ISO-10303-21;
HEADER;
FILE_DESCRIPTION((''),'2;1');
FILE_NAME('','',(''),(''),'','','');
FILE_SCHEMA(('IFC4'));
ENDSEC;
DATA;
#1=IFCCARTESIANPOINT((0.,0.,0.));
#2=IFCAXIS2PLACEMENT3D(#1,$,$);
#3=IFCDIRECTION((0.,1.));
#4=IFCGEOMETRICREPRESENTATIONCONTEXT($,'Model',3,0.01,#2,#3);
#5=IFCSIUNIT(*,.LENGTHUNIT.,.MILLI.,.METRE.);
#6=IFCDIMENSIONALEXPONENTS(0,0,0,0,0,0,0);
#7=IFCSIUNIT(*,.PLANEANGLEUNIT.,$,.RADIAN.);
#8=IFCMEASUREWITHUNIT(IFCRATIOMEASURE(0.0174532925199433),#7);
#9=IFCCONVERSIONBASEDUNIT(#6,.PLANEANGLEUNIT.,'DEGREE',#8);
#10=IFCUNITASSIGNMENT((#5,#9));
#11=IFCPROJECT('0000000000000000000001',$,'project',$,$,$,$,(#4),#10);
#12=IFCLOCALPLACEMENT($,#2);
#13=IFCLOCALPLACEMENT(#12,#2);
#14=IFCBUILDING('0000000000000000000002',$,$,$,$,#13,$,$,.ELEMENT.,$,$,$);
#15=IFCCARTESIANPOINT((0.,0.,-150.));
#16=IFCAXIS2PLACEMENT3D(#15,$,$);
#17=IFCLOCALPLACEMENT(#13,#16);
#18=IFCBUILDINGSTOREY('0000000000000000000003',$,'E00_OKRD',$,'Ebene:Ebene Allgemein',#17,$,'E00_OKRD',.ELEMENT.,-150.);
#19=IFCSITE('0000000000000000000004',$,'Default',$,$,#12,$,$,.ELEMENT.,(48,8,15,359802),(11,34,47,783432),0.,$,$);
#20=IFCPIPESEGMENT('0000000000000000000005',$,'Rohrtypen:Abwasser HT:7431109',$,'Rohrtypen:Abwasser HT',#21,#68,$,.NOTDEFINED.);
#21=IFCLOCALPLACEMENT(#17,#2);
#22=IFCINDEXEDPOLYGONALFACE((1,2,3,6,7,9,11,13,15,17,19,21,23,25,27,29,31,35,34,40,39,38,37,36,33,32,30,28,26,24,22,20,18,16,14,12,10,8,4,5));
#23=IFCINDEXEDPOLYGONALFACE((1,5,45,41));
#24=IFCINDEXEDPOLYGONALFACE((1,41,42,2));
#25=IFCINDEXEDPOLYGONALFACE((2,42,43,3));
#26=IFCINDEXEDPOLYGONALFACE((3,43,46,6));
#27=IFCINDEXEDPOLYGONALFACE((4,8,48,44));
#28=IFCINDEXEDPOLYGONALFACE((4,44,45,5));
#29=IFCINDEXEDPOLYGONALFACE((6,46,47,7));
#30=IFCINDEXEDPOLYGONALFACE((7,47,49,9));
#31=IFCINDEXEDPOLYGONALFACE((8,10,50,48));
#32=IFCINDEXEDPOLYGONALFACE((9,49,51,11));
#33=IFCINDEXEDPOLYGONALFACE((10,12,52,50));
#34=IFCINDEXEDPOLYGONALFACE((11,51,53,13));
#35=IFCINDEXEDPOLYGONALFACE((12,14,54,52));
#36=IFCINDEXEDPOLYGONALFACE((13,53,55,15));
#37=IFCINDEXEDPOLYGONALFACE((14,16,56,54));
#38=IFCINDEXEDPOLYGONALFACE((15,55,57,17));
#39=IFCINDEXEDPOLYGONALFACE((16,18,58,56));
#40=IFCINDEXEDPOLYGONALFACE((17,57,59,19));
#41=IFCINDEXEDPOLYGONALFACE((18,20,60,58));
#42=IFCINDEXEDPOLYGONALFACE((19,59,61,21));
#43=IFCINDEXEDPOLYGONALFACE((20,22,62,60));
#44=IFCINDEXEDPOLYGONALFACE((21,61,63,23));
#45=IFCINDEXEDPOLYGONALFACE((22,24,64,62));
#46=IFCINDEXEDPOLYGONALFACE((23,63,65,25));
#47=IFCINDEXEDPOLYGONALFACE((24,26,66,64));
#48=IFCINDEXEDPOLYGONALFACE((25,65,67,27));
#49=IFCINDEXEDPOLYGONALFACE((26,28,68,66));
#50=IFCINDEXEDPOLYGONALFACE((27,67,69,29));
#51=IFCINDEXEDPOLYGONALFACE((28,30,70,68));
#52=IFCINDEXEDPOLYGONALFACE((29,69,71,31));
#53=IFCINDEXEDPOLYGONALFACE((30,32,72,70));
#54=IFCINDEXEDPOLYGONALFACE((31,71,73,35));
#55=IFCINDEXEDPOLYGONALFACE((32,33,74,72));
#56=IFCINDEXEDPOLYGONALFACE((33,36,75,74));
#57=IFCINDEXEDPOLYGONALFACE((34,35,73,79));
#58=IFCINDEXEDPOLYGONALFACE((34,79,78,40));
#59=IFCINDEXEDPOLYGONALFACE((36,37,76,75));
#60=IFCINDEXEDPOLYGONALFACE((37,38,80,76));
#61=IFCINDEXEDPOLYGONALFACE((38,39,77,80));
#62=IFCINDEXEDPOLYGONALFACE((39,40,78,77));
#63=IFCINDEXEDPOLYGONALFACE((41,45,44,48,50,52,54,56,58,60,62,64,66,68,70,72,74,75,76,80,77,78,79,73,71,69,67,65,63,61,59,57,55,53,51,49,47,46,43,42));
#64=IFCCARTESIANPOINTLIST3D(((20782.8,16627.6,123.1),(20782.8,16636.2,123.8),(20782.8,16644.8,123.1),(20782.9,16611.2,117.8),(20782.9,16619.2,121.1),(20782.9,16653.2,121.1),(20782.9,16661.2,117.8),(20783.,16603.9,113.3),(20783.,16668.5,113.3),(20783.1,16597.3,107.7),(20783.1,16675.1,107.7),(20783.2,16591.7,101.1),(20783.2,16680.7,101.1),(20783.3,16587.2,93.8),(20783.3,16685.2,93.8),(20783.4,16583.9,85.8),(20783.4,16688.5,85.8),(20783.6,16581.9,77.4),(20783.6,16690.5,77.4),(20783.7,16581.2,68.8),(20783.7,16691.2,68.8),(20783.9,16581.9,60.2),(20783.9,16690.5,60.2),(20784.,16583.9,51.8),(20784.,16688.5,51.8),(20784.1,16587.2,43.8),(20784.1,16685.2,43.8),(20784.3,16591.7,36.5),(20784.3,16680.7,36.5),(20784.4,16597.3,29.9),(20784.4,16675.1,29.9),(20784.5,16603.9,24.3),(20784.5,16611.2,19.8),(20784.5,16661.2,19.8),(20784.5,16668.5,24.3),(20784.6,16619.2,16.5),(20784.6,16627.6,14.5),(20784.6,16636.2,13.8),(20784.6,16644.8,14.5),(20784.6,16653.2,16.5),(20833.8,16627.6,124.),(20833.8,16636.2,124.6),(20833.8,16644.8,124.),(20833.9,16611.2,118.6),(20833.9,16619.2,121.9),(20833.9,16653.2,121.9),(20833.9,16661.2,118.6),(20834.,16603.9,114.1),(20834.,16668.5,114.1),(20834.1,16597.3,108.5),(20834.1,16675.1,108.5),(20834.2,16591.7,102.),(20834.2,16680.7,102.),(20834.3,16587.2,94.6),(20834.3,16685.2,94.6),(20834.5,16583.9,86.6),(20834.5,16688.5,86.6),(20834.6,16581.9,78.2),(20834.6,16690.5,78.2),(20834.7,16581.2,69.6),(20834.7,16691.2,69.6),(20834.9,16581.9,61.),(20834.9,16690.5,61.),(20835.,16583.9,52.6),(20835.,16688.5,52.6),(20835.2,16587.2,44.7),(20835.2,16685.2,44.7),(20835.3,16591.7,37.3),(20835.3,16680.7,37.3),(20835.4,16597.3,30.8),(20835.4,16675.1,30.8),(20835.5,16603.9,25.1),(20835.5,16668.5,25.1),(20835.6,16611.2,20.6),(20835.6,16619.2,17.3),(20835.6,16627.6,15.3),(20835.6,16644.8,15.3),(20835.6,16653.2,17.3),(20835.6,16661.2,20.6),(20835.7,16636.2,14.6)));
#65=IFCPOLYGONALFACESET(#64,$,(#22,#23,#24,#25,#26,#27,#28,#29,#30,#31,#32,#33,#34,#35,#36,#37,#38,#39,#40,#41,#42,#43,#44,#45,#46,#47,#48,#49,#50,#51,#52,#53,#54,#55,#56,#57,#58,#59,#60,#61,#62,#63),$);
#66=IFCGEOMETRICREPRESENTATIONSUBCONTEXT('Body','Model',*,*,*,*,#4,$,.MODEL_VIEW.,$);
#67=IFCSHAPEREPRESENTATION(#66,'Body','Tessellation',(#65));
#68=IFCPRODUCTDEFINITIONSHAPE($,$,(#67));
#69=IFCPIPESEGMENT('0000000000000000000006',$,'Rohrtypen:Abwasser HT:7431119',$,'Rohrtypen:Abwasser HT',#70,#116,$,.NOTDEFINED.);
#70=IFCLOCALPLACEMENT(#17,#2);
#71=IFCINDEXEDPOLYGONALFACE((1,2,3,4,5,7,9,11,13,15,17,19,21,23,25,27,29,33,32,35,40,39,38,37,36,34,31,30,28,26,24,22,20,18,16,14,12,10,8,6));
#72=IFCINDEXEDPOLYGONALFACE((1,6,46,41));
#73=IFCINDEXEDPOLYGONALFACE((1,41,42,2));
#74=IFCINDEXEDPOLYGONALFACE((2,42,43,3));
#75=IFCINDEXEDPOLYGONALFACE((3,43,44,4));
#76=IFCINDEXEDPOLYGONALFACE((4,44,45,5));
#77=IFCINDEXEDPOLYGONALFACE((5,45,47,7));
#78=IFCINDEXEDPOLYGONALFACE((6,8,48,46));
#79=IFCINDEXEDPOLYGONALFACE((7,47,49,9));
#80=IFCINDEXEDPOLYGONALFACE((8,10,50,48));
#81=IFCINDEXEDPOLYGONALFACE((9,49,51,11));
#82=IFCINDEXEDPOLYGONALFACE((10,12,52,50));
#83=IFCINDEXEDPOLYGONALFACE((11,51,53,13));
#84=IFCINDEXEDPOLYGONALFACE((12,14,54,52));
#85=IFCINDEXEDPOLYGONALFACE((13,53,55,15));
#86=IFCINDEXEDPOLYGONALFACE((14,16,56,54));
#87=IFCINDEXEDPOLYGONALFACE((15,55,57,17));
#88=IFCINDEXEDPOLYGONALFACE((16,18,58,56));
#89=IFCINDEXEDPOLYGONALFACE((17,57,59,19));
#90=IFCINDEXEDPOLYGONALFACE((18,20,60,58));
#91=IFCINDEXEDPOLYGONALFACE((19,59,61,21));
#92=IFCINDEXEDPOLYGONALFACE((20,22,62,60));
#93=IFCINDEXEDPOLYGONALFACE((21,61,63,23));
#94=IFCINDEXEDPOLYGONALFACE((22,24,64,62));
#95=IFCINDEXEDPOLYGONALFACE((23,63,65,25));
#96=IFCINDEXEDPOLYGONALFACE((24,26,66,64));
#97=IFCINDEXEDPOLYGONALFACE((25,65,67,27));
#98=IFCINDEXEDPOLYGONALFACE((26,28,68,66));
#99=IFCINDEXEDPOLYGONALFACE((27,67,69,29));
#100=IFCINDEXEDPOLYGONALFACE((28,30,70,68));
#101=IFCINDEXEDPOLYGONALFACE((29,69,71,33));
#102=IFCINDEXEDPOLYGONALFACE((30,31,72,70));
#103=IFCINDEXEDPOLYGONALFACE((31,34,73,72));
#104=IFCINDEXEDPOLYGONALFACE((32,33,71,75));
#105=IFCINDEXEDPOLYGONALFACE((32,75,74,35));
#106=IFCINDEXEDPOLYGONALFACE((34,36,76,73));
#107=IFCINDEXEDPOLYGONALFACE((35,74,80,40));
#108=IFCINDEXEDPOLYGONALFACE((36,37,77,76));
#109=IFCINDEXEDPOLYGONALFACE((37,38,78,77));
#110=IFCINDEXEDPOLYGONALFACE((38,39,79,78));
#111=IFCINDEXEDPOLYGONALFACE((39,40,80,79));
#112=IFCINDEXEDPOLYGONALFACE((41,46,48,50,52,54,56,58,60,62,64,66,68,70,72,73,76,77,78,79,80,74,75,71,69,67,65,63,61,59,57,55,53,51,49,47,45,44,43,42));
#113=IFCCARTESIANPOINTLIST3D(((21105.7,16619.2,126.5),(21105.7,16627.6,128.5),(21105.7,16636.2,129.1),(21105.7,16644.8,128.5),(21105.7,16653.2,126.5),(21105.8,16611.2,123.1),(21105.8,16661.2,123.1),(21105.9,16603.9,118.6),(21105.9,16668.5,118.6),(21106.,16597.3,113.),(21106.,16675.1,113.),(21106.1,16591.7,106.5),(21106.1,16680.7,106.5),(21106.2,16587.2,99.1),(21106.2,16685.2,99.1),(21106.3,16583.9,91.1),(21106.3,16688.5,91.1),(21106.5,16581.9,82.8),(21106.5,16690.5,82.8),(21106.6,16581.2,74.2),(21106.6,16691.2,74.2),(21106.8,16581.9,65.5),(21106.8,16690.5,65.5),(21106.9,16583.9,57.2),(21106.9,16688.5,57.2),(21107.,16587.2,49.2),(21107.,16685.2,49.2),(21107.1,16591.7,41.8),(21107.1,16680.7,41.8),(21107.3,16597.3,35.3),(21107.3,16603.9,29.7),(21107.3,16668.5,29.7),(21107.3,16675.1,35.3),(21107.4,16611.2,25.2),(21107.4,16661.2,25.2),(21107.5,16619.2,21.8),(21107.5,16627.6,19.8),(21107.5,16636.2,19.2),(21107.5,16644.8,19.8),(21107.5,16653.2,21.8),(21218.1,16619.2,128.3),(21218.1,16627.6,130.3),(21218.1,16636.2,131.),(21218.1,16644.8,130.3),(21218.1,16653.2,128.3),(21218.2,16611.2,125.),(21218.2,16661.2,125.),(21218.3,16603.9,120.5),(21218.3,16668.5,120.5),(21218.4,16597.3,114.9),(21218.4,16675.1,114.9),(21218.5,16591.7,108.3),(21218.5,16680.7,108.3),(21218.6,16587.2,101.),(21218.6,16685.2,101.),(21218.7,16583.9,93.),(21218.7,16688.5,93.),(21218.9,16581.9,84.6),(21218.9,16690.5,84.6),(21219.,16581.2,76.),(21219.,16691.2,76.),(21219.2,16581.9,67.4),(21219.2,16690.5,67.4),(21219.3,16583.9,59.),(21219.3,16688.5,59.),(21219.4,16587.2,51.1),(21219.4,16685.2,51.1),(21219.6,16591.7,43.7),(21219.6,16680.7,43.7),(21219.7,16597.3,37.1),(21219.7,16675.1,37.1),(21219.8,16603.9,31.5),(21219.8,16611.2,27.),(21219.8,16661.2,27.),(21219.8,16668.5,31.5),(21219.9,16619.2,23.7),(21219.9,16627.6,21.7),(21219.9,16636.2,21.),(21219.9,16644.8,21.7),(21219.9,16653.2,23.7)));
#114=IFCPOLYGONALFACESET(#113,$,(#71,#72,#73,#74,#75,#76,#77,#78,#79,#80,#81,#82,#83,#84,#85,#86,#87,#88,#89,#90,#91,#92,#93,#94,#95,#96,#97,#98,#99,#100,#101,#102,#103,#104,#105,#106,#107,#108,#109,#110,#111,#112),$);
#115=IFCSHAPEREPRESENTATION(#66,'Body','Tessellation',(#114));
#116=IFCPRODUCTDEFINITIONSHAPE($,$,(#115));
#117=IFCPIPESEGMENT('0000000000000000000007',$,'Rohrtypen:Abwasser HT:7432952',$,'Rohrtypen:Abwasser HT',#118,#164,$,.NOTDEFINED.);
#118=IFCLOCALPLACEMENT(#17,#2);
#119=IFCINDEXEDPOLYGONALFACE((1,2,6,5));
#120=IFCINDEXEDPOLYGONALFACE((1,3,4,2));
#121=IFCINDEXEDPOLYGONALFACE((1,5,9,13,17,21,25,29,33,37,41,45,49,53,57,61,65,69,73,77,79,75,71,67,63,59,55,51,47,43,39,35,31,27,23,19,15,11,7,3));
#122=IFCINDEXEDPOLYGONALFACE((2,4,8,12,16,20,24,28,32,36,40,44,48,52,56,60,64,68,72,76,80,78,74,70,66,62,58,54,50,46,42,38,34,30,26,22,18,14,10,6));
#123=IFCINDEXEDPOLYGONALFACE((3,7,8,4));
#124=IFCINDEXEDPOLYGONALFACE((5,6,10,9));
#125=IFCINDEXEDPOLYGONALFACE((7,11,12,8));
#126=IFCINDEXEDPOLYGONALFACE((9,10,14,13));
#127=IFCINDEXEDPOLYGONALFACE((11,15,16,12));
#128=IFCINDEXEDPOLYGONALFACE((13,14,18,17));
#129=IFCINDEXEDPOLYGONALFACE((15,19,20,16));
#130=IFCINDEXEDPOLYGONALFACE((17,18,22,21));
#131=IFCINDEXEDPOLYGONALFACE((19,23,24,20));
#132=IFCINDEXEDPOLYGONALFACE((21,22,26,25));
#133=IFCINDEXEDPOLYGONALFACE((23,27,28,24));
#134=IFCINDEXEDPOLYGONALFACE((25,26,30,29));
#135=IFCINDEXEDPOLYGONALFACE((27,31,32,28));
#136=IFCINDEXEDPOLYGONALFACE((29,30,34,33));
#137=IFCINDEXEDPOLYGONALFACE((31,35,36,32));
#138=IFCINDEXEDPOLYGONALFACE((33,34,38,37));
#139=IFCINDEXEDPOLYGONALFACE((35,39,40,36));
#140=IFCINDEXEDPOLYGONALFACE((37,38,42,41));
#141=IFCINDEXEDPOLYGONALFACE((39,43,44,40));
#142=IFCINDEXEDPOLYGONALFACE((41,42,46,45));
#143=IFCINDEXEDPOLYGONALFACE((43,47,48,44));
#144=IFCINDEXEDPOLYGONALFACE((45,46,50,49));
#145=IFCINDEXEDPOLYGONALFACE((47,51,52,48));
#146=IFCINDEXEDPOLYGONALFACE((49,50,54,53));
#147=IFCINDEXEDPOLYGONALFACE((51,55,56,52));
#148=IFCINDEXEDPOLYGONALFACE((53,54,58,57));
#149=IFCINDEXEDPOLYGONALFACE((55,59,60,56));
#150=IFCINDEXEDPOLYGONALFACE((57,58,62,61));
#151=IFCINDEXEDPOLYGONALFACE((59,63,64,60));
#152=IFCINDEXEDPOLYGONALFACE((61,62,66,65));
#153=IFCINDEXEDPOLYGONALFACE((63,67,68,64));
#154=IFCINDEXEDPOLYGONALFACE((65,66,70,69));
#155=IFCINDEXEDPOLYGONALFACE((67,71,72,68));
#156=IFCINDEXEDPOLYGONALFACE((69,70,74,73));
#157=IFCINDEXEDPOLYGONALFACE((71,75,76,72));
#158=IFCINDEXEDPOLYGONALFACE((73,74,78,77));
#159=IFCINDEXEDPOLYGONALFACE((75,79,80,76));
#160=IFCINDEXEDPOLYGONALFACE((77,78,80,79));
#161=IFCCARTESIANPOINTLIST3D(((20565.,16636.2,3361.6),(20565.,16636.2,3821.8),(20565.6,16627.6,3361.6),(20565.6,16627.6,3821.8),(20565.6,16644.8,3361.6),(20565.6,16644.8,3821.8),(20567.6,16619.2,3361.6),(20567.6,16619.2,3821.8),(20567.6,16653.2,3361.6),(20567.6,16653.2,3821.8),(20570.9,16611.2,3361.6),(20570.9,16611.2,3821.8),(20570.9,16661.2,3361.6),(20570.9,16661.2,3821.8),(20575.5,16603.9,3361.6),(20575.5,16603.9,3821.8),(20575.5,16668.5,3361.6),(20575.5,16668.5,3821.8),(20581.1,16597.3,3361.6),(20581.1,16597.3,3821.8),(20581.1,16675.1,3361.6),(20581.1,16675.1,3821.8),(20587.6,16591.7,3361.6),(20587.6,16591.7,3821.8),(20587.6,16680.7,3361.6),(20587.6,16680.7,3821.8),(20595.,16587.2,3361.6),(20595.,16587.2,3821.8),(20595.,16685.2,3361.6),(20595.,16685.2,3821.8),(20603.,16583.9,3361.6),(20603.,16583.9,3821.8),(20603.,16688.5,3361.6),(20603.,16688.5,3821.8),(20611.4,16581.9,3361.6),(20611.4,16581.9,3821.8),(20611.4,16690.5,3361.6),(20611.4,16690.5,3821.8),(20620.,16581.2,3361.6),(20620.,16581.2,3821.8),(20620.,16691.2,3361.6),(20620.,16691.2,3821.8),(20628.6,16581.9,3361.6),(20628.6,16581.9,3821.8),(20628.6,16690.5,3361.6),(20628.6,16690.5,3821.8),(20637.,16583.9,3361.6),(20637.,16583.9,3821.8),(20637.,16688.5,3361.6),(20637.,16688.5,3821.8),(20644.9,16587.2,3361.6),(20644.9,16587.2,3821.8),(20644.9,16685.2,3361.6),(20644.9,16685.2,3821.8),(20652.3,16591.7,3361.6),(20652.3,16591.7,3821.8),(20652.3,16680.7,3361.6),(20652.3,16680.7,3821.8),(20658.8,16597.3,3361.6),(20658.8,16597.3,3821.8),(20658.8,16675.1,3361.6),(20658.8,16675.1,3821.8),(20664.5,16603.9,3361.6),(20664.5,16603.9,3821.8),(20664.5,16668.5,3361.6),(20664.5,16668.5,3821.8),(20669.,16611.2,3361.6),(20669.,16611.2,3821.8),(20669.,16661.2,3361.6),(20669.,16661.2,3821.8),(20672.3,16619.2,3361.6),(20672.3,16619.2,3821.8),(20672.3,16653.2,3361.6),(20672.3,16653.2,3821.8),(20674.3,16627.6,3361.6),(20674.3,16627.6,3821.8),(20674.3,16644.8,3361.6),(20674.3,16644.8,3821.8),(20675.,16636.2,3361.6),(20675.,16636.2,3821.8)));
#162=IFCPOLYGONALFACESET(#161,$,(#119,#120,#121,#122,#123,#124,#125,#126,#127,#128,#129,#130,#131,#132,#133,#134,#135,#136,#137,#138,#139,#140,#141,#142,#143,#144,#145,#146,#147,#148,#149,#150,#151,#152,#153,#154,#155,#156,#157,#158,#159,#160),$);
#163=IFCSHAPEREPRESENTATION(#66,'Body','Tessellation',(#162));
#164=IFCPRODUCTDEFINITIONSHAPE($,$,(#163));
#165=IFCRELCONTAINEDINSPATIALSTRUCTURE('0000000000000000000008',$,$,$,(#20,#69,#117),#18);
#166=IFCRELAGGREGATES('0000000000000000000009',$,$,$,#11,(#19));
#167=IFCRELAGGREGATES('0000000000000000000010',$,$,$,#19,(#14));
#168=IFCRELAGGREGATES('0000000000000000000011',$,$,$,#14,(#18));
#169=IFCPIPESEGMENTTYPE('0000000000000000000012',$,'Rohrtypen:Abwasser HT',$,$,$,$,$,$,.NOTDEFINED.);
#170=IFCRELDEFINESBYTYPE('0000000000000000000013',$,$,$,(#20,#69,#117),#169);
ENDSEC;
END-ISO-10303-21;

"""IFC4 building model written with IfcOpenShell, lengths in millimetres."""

from ifc_helpers import new_model, entity, si_unit, converted_unit, direction, frame, origin, place, context, subcontext, project, spatial, indexed_curve, outline, extrude, type_object, element, save


model = new_model("IFC4")

# Units and contexts
model_context = context("Model", 3, precision=0.01, world=origin(), true_north=direction((0.0, 1.0)))
body_context = subcontext(model_context, "Body", "Model", "MODEL_VIEW")
ifc_project = project(units=[si_unit("LENGTHUNIT", "METRE", prefix="MILLI"), converted_unit("PLANEANGLEUNIT", "DEGREE", entity("IfcRatioMeasure", 0.0174532925199433), si_unit("PLANEANGLEUNIT", "RADIAN"), dimensions=[0, 0, 0, 0, 0, 0, 0])], contexts=[model_context])

# Site, building, storey
site_placement = place(None, origin())
site = spatial("IfcSite", under=ifc_project, at=site_placement, Name="Default", CompositionType="ELEMENT", RefLatitude=(48, 8, 15, 359802), RefLongitude=(11, 34, 47, 783432), RefElevation=0.0)
building_placement = place(site_placement, origin())
building = spatial("IfcBuilding", under=site, at=building_placement, CompositionType="ELEMENT")
storey_placement = place(building_placement, frame((0.0, 0.0, -150.0)))
storey = spatial("IfcBuildingStorey", under=building, at=storey_placement, Name="E00_OKRD", ObjectType="Ebene:Ebene Allgemein", LongName="E00_OKRD", CompositionType="ELEMENT", Elevation=-150.0)

# Pipe segments
pipe_segment_type_1 = type_object("IfcPipeSegmentType", Name="Rohrtypen:Abwasser HT", PredefinedType="NOTDEFINED")
pipe_segment_1_placement = place(storey_placement, origin())
element("IfcPipeSegment", 1, at=pipe_segment_1_placement, inside=storey, type_object=pipe_segment_type_1, Name="Rohrtypen:Abwasser HT:7431109", ObjectType="Rohrtypen:Abwasser HT", PredefinedType="NOTDEFINED", context=body_context, shape_type="SweptSolid", body=[
    extrude(outline(indexed_curve([(55.0, 0.0), (54.3, 8.6), (52.3, 17.0), (49.0, 25.0), (44.5, 32.3), (38.9, 38.9), (32.3, 44.5), (25.0, 49.0), (17.0, 52.3), (8.6, 54.3), (0.0, 55.0), (-8.6, 54.3), (-17.0, 52.3), (-25.0, 49.0), (-32.3, 44.5), (-38.9, 38.9), (-44.5, 32.3), (-49.0, 25.0), (-52.3, 17.0), (-54.3, 8.6), (-55.0, 0.0), (-54.3, -8.6), (-52.3, -17.0), (-49.0, -25.0), (-44.5, -32.3), (-38.9, -38.9), (-32.3, -44.5), (-25.0, -49.0), (-17.0, -52.3), (-8.6, -54.3), (0.0, -55.0), (8.6, -54.3), (17.0, -52.3), (25.0, -49.0), (32.3, -44.5), (38.9, -38.9), (44.5, -32.3), (49.0, -25.0), (52.3, -17.0), (54.3, -8.6), (55.0, 0.0)], self_intersect=False)), frame((20783.7, 16636.2, 68.8), z_axis=(0.999862, 0.0, 0.016604), x_axis=(0.0, 1.0, 0.0)), (0.0, 0.0, 1.0), 51.0),
])
pipe_segment_2_placement = place(storey_placement, origin())
element("IfcPipeSegment", 2, at=pipe_segment_2_placement, inside=storey, type_object=pipe_segment_type_1, Name="Rohrtypen:Abwasser HT:7431119", ObjectType="Rohrtypen:Abwasser HT", PredefinedType="NOTDEFINED", context=body_context, shape_type="SweptSolid", body=[
    extrude(outline(indexed_curve([(55.0, 0.0), (54.3, 8.6), (52.3, 17.0), (49.0, 25.0), (44.5, 32.3), (38.9, 38.9), (32.3, 44.5), (25.0, 49.0), (17.0, 52.3), (8.6, 54.3), (0.0, 55.0), (-8.6, 54.3), (-17.0, 52.3), (-25.0, 49.0), (-32.3, 44.5), (-38.9, 38.9), (-44.5, 32.3), (-49.0, 25.0), (-52.3, 17.0), (-54.3, 8.6), (-55.0, 0.0), (-54.3, -8.6), (-52.3, -17.0), (-49.0, -25.0), (-44.5, -32.3), (-38.9, -38.9), (-32.3, -44.5), (-25.0, -49.0), (-17.0, -52.3), (-8.6, -54.3), (0.0, -55.0), (8.6, -54.3), (17.0, -52.3), (25.0, -49.0), (32.3, -44.5), (38.9, -38.9), (44.5, -32.3), (49.0, -25.0), (52.3, -17.0), (54.3, -8.6), (55.0, 0.0)], self_intersect=False)), frame((21106.6, 16636.2, 74.2), z_axis=(0.999862, 0.0, 0.016604), x_axis=(0.0, 1.0, 0.0)), (0.0, 0.0, 1.0), 112.4),
])
pipe_segment_3_placement = place(storey_placement, origin())
element("IfcPipeSegment", 3, at=pipe_segment_3_placement, inside=storey, type_object=pipe_segment_type_1, Name="Rohrtypen:Abwasser HT:7432952", ObjectType="Rohrtypen:Abwasser HT", PredefinedType="NOTDEFINED", context=body_context, shape_type="SweptSolid", body=[
    extrude(outline(indexed_curve([(55.0, 0.0), (54.3, 8.6), (52.3, 17.0), (49.0, 25.0), (44.5, 32.3), (38.9, 38.9), (32.3, 44.5), (25.0, 49.0), (17.0, 52.3), (8.6, 54.3), (0.0, 55.0), (-8.6, 54.3), (-17.0, 52.3), (-25.0, 49.0), (-32.3, 44.5), (-38.9, 38.9), (-44.5, 32.3), (-49.0, 25.0), (-52.3, 17.0), (-54.3, 8.6), (-55.0, 0.0), (-54.3, -8.6), (-52.3, -17.0), (-49.0, -25.0), (-44.5, -32.3), (-38.9, -38.9), (-32.3, -44.5), (-25.0, -49.0), (-17.0, -52.3), (-8.6, -54.3), (0.0, -55.0), (8.6, -54.3), (17.0, -52.3), (25.0, -49.0), (32.3, -44.5), (38.9, -38.9), (44.5, -32.3), (49.0, -25.0), (52.3, -17.0), (54.3, -8.6), (55.0, 0.0)], self_intersect=False)), frame((20620.0, 16636.2, 3361.6), z_axis=(0.0, 0.0, 1.0), x_axis=(-1.0, 0.0, 0.0)), (0.0, 0.0, 1.0), 460.2),
])

save(model, "model.ifc")
